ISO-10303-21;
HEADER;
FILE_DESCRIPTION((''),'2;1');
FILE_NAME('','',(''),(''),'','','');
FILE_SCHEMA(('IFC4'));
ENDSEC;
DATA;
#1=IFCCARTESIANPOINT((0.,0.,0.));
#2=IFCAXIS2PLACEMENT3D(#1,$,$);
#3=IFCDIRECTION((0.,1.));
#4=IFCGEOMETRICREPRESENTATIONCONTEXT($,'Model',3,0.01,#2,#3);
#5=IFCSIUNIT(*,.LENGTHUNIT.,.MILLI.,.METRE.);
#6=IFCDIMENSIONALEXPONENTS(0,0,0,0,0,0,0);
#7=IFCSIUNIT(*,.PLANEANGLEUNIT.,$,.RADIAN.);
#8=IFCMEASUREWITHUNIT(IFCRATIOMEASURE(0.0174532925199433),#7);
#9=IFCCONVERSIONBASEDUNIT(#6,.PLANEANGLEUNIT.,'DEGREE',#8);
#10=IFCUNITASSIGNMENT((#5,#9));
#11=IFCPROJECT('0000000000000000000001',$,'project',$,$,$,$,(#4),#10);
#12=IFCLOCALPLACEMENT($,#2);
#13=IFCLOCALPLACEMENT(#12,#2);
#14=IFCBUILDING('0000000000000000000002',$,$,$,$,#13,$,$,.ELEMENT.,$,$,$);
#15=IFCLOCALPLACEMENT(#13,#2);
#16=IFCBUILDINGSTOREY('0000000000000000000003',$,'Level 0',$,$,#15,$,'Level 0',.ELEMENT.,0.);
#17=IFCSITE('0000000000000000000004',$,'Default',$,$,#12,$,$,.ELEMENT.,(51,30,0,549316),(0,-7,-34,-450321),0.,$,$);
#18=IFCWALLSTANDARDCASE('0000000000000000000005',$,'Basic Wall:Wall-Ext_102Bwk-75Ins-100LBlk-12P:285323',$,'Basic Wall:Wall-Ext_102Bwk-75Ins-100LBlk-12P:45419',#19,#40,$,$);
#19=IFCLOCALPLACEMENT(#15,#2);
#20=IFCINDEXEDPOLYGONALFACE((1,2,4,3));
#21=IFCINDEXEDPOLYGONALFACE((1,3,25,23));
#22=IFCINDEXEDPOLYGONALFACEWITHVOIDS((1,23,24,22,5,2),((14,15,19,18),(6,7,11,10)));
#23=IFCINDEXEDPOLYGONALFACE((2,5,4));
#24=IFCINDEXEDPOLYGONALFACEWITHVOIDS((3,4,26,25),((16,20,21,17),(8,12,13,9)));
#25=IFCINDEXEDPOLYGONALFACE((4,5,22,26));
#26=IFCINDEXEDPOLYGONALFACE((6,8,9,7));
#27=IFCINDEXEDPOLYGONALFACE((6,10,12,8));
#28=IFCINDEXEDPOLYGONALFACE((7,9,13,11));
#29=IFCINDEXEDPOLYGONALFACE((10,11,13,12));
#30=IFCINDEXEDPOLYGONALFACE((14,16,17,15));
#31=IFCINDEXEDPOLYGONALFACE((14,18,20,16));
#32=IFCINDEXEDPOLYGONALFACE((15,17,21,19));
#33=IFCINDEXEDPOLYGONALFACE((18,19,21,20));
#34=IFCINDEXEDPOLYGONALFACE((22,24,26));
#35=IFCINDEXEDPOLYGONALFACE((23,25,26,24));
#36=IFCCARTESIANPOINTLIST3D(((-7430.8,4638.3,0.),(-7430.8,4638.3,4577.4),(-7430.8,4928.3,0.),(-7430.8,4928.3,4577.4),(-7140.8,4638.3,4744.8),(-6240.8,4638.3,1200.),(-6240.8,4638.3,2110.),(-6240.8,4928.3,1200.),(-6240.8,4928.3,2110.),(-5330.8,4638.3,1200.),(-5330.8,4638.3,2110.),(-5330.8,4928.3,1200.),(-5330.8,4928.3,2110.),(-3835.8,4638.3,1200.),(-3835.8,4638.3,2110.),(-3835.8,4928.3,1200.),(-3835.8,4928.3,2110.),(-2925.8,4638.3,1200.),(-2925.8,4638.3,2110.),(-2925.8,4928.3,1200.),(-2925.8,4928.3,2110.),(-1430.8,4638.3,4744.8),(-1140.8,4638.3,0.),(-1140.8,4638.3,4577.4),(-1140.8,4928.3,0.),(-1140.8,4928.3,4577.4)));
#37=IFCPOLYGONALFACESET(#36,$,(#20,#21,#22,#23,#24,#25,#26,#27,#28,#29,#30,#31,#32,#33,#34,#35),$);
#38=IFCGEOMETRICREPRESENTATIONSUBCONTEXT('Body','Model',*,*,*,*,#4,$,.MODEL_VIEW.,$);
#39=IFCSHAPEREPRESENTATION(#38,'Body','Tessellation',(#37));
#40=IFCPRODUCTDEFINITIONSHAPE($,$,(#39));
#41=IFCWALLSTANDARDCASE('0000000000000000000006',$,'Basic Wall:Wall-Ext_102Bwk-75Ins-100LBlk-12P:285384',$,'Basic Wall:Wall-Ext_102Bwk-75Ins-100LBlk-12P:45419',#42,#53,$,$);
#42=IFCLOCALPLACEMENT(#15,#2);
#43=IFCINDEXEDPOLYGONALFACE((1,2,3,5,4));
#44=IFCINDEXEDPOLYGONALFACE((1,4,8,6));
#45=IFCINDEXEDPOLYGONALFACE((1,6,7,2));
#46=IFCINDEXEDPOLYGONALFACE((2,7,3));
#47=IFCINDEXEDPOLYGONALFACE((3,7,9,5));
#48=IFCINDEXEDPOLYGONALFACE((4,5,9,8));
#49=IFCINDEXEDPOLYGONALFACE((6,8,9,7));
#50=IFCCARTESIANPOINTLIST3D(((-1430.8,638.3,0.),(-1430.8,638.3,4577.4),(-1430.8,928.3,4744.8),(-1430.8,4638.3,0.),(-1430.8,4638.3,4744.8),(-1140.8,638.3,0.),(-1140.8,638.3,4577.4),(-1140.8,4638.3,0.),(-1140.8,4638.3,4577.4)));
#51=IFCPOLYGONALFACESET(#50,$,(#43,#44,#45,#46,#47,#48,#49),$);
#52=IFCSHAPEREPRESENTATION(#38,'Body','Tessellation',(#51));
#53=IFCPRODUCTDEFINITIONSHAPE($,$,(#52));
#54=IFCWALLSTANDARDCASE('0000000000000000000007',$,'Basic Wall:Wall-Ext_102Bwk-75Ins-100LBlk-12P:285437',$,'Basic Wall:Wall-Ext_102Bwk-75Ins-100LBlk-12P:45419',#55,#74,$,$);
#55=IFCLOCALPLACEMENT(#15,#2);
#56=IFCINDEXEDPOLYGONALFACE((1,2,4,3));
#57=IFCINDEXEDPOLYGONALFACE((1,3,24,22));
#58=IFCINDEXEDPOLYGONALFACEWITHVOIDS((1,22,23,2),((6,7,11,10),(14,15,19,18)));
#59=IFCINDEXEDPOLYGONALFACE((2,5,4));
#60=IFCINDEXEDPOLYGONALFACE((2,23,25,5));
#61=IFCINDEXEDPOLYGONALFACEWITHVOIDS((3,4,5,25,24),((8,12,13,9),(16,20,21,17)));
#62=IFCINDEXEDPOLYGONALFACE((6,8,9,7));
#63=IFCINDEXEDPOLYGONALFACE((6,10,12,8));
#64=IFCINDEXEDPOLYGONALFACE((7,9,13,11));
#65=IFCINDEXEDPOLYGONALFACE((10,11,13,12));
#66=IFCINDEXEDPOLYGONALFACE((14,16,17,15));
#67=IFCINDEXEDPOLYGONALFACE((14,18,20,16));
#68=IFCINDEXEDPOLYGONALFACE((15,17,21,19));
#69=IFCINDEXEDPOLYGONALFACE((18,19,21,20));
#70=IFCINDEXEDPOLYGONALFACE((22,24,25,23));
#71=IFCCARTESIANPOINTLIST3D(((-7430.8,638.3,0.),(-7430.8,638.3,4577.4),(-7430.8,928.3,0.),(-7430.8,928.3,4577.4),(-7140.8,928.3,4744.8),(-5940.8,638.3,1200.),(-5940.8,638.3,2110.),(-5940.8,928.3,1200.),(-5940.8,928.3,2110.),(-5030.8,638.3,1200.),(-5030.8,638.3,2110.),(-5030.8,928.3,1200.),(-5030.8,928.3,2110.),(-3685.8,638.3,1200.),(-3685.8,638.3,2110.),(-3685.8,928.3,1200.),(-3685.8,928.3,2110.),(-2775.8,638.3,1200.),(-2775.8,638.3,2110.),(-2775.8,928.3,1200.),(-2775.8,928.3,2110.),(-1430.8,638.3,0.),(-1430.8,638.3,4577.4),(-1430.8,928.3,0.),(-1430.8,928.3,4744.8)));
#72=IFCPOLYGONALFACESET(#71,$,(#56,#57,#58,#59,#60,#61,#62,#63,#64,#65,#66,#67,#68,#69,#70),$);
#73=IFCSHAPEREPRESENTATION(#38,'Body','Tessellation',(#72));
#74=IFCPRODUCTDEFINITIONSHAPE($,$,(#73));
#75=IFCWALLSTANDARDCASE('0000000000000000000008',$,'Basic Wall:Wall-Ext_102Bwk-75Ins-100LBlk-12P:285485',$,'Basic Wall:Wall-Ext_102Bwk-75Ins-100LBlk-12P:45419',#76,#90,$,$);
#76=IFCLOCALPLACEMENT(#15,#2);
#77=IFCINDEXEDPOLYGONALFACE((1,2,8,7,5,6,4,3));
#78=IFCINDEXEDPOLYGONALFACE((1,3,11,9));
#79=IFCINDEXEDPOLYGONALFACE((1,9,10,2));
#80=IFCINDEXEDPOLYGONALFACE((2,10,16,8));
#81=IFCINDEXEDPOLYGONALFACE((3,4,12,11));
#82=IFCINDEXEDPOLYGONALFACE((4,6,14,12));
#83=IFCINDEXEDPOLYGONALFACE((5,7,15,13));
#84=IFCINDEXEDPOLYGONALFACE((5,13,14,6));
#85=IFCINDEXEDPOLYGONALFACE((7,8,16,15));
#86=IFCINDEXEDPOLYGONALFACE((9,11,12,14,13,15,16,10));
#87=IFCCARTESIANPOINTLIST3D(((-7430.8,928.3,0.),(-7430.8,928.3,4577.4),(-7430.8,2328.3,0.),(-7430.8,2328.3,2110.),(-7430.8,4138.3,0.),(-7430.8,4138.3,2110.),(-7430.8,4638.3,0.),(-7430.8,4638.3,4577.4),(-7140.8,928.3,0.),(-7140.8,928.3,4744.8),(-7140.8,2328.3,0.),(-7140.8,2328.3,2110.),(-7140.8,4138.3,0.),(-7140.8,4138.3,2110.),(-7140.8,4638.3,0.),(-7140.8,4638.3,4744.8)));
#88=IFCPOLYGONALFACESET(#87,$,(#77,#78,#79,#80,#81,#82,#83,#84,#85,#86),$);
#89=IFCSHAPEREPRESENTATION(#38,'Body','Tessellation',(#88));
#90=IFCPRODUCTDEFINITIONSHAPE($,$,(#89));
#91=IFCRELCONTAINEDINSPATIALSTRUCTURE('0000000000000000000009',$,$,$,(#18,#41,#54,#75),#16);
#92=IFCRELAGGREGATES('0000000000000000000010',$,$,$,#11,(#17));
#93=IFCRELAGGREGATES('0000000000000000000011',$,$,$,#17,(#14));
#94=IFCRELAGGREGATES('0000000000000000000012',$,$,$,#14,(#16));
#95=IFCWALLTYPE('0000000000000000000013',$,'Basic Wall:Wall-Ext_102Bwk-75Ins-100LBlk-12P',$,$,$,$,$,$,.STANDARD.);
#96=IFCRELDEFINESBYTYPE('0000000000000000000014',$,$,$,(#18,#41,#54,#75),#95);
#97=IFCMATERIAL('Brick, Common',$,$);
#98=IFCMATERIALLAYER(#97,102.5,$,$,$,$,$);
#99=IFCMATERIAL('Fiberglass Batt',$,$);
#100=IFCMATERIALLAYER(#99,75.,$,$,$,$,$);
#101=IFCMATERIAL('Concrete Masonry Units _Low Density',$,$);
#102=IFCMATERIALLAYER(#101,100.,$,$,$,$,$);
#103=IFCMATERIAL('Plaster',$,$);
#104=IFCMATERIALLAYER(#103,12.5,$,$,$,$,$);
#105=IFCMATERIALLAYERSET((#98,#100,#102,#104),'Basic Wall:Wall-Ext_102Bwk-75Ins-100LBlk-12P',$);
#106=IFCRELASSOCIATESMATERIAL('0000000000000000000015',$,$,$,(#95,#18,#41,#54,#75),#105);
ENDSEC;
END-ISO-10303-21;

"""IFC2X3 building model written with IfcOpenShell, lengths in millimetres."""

from ifc_helpers import new_model, entity, si_unit, converted_unit, direction, frame, frame_2d, origin, place, context, subcontext, project, spatial, polyline, rectangle, extrude, clip, bounded_halfspace, material, layer, layer_set, layer_usage, type_object, element, save


model = new_model("IFC2X3")

# Units and contexts
model_context = context("Model", 3, precision=0.01, world=origin(), true_north=direction((0.0, 1.0)))
body_context = subcontext(model_context, "Body", "Model", "MODEL_VIEW")
ifc_project = project(units=[si_unit("LENGTHUNIT", "METRE", prefix="MILLI"), converted_unit("PLANEANGLEUNIT", "DEGREE", entity("IfcRatioMeasure", 0.0174532925199433), si_unit("PLANEANGLEUNIT", "RADIAN"), dimensions=[0, 0, 0, 0, 0, 0, 0])], contexts=[model_context])

# Site, building, storey
site_placement = place(None, origin())
site = spatial("IfcSite", under=ifc_project, at=site_placement, Name="Default", CompositionType="ELEMENT", RefLatitude=(51, 30, 0, 549316), RefLongitude=(0, -7, -34, -450321), RefElevation=0.0)
building_placement = place(site_placement, origin())
building = spatial("IfcBuilding", under=site, at=building_placement, CompositionType="ELEMENT")
storey_placement = place(building_placement, origin())
storey = spatial("IfcBuildingStorey", under=building, at=storey_placement, Name="Level 0", LongName="Level 0", CompositionType="ELEMENT", Elevation=0.0)

# Wall, openings
ifc_material_1 = material(Name="Brick, Common")
ifc_layer_1 = layer(ifc_material_1, 102.5)
ifc_material_2 = material(Name="Fiberglass Batt")
ifc_layer_2 = layer(ifc_material_2, 75.0)
ifc_material_3 = material(Name="Concrete Masonry Units _Low Density")
ifc_layer_3 = layer(ifc_material_3, 100.0)
ifc_material_4 = material(Name="Plaster")
ifc_layer_4 = layer(ifc_material_4, 12.5)
ifc_layer_set = layer_set([ifc_layer_1, ifc_layer_2, ifc_layer_3, ifc_layer_4], Name="Basic Wall:Wall-Ext_102Bwk-75Ins-100LBlk-12P")
ifc_layer_usage_1 = layer_usage(ifc_layer_set, "AXIS2", "NEGATIVE", 145.0)
wall_type = type_object("IfcWallType", Name="Basic Wall:Wall-Ext_102Bwk-75Ins-100LBlk-12P", PredefinedType="STANDARD", material=ifc_layer_set)
wall_1_placement = place(storey_placement, frame((-7430.8, 4783.3, 0.0)))
wall_1 = element("IfcWallStandardCase", 1, at=wall_1_placement, inside=storey, type_object=wall_type, material=ifc_layer_usage_1, Name="Basic Wall:Wall-Ext_102Bwk-75Ins-100LBlk-12P:285323", ObjectType="Basic Wall:Wall-Ext_102Bwk-75Ins-100LBlk-12P:45419", context=body_context, shape_type="Clipping", body=[
    clip(clip(clip(extrude(rectangle(XDim=6290.0, YDim=290.0, at=frame_2d((3145.0, 0.0), x_axis=(-1.0, 0.0))), origin(), (0.0, 0.0, 1.0), 8000.0), bounded_halfspace(frame((6000.0, -145.0, 4744.8), z_axis=(0.5, 0.0, 0.866025), x_axis=(0.0, 1.0, 0.0)), False, frame((6000.0, -145.0, 4744.8)), polyline([(0.0, 0.0), (290.0, 0.0), (290.0, 290.0), (0.0, 0.0)]))), bounded_halfspace(frame((0.0, -145.0, 4577.4), z_axis=(-0.5, 0.0, 0.866025), x_axis=(0.0, -1.0, 0.0)), False, frame((0.0, -145.0, 4577.4)), polyline([(0.0, 0.0), (290.0, 0.0), (0.0, 290.0), (0.0, 0.0)]))), bounded_halfspace(frame((290.0, -145.0, 4744.8), z_axis=(0.0, 0.5, 0.866025), x_axis=(-1.0, 0.0, 0.0)), False, frame((290.0, -145.0, 4744.8)), polyline([(0.0, 0.0), (5710.0, 0.0), (6000.0, 290.0), (-290.0, 290.0), (0.0, 0.0)]))),
])
opening_1_placement = place(wall_1_placement, frame((1190.0, -145.0, 1200.0)))
element("IfcOpeningElement", 2, at=opening_1_placement, cuts=wall_1, ObjectType="Opening", context=body_context, shape_type="SweptSolid", body=[
    extrude(rectangle(XDim=910.0, YDim=910.0, at=frame_2d((455.0, 455.0), x_axis=(-1.0, 0.0))), frame((0.0, 0.0, 0.0), z_axis=(0.0, 1.0, 0.0), x_axis=(0.0, 0.0, 1.0)), (0.0, 0.0, 1.0), 290.0),
])
opening_2_placement = place(wall_1_placement, frame((3595.0, -145.0, 1200.0)))
element("IfcOpeningElement", 3, at=opening_2_placement, cuts=wall_1, ObjectType="Opening", context=body_context, shape_type="SweptSolid", body=[
    extrude(rectangle(XDim=910.0, YDim=910.0, at=frame_2d((455.0, 455.0), x_axis=(-1.0, 0.0))), frame((0.0, 0.0, 0.0), z_axis=(0.0, 1.0, 0.0), x_axis=(0.0, 0.0, 1.0)), (0.0, 0.0, 1.0), 290.0),
])

# Wall
ifc_layer_usage_2 = layer_usage(ifc_layer_set, "AXIS2", "NEGATIVE", 145.0)
wall_2_placement = place(storey_placement, frame((-1285.8, 4638.3, 0.0), z_axis=(0.0, 0.0, 1.0), x_axis=(0.0, -1.0, 0.0)))
element("IfcWallStandardCase", 4, at=wall_2_placement, inside=storey, type_object=wall_type, material=ifc_layer_usage_2, Name="Basic Wall:Wall-Ext_102Bwk-75Ins-100LBlk-12P:285384", ObjectType="Basic Wall:Wall-Ext_102Bwk-75Ins-100LBlk-12P:45419", context=body_context, shape_type="Clipping", body=[
    clip(clip(extrude(rectangle(XDim=4000.0, YDim=290.0, at=frame_2d((2000.0, 0.0), x_axis=(-1.0, 0.0))), origin(), (0.0, 0.0, 1.0), 8000.0), bounded_halfspace(frame((0.0, -145.0, 4744.8), z_axis=(0.0, 0.5, 0.866025), x_axis=(-1.0, 0.0, 0.0)), False, frame((0.0, -145.0, 4744.8)), polyline([(0.0, 0.0), (3710.0, 0.0), (4000.0, 290.0), (0.0, 290.0), (0.0, 0.0)]))), bounded_halfspace(frame((3710.0, -145.0, 4744.8), z_axis=(0.5, 0.0, 0.866025), x_axis=(0.0, 1.0, 0.0)), False, frame((3710.0, -145.0, 4744.8)), polyline([(0.0, 0.0), (290.0, 0.0), (290.0, 290.0), (0.0, 0.0)]))),
])

# Wall, openings
ifc_layer_usage_3 = layer_usage(ifc_layer_set, "AXIS2", "NEGATIVE", 145.0)
wall_3_placement = place(storey_placement, frame((-1430.8, 783.3, 0.0), z_axis=(0.0, 0.0, 1.0), x_axis=(-1.0, 0.0, 0.0)))
wall_3 = element("IfcWallStandardCase", 5, at=wall_3_placement, inside=storey, type_object=wall_type, material=ifc_layer_usage_3, Name="Basic Wall:Wall-Ext_102Bwk-75Ins-100LBlk-12P:285437", ObjectType="Basic Wall:Wall-Ext_102Bwk-75Ins-100LBlk-12P:45419", context=body_context, shape_type="Clipping", body=[
    clip(clip(extrude(rectangle(XDim=6000.0, YDim=290.0, at=frame_2d((3000.0, 0.0), x_axis=(-1.0, 0.0))), origin(), (0.0, 0.0, 1.0), 8000.0), bounded_halfspace(frame((5710.0, -145.0, 4744.8), z_axis=(0.5, 0.0, 0.866025), x_axis=(0.0, 1.0, 0.0)), False, frame((5710.0, -145.0, 4744.8)), polyline([(0.0, 0.0), (290.0, 0.0), (290.0, 290.0), (0.0, 0.0)]))), bounded_halfspace(frame((0.0, -145.0, 4744.8), z_axis=(0.0, 0.5, 0.866025), x_axis=(-1.0, 0.0, 0.0)), False, frame((0.0, -145.0, 4744.8)), polyline([(0.0, 0.0), (5710.0, 0.0), (6000.0, 290.0), (0.0, 290.0), (0.0, 0.0)]))),
])
opening_3_placement = place(wall_3_placement, frame((3600.0, -145.0, 1200.0)))
element("IfcOpeningElement", 6, at=opening_3_placement, cuts=wall_3, ObjectType="Opening", context=body_context, shape_type="SweptSolid", body=[
    extrude(rectangle(XDim=910.0, YDim=910.0, at=frame_2d((455.0, 455.0), x_axis=(-1.0, 0.0))), frame((0.0, 0.0, 0.0), z_axis=(0.0, 1.0, 0.0), x_axis=(0.0, 0.0, 1.0)), (0.0, 0.0, 1.0), 290.0),
])
opening_4_placement = place(wall_3_placement, frame((1345.0, -145.0, 1200.0)))
element("IfcOpeningElement", 7, at=opening_4_placement, cuts=wall_3, ObjectType="Opening", context=body_context, shape_type="SweptSolid", body=[
    extrude(rectangle(XDim=910.0, YDim=910.0, at=frame_2d((455.0, 455.0), x_axis=(-1.0, 0.0))), frame((0.0, 0.0, 0.0), z_axis=(0.0, 1.0, 0.0), x_axis=(0.0, 0.0, 1.0)), (0.0, 0.0, 1.0), 290.0),
])

# Wall, opening
ifc_layer_usage_4 = layer_usage(ifc_layer_set, "AXIS2", "NEGATIVE", 145.0)
wall_4_placement = place(storey_placement, frame((-7285.8, 928.3, 0.0), z_axis=(0.0, 0.0, 1.0), x_axis=(0.0, 1.0, 0.0)))
wall_4 = element("IfcWallStandardCase", 8, at=wall_4_placement, inside=storey, type_object=wall_type, material=ifc_layer_usage_4, Name="Basic Wall:Wall-Ext_102Bwk-75Ins-100LBlk-12P:285485", ObjectType="Basic Wall:Wall-Ext_102Bwk-75Ins-100LBlk-12P:45419", context=body_context, shape_type="Clipping", body=[
    clip(extrude(rectangle(XDim=3710.0, YDim=290.0, at=frame_2d((1855.0, 0.0), x_axis=(-1.0, 0.0))), origin(), (0.0, 0.0, 1.0), 8000.0), bounded_halfspace(frame((0.0, -145.0, 4744.8), z_axis=(0.0, 0.5, 0.866025), x_axis=(-1.0, 0.0, 0.0)), False, frame((0.0, -145.0, 4744.8)), polyline([(0.0, 0.0), (3710.0, 0.0), (3710.0, 290.0), (0.0, 290.0), (0.0, 0.0)]))),
])
opening_5_placement = place(wall_4_placement, frame((1400.0, -145.0, 0.0)))
element("IfcOpeningElement", 9, at=opening_5_placement, cuts=wall_4, ObjectType="Opening", context=body_context, shape_type="SweptSolid", body=[
    extrude(rectangle(XDim=2110.0, YDim=1810.0, at=frame_2d((1055.0, 905.0), x_axis=(-1.0, 0.0))), frame((0.0, 0.0, 0.0), z_axis=(0.0, 1.0, 0.0), x_axis=(0.0, 0.0, 1.0)), (0.0, 0.0, 1.0), 290.0),
])

save(model, "model.ifc")
